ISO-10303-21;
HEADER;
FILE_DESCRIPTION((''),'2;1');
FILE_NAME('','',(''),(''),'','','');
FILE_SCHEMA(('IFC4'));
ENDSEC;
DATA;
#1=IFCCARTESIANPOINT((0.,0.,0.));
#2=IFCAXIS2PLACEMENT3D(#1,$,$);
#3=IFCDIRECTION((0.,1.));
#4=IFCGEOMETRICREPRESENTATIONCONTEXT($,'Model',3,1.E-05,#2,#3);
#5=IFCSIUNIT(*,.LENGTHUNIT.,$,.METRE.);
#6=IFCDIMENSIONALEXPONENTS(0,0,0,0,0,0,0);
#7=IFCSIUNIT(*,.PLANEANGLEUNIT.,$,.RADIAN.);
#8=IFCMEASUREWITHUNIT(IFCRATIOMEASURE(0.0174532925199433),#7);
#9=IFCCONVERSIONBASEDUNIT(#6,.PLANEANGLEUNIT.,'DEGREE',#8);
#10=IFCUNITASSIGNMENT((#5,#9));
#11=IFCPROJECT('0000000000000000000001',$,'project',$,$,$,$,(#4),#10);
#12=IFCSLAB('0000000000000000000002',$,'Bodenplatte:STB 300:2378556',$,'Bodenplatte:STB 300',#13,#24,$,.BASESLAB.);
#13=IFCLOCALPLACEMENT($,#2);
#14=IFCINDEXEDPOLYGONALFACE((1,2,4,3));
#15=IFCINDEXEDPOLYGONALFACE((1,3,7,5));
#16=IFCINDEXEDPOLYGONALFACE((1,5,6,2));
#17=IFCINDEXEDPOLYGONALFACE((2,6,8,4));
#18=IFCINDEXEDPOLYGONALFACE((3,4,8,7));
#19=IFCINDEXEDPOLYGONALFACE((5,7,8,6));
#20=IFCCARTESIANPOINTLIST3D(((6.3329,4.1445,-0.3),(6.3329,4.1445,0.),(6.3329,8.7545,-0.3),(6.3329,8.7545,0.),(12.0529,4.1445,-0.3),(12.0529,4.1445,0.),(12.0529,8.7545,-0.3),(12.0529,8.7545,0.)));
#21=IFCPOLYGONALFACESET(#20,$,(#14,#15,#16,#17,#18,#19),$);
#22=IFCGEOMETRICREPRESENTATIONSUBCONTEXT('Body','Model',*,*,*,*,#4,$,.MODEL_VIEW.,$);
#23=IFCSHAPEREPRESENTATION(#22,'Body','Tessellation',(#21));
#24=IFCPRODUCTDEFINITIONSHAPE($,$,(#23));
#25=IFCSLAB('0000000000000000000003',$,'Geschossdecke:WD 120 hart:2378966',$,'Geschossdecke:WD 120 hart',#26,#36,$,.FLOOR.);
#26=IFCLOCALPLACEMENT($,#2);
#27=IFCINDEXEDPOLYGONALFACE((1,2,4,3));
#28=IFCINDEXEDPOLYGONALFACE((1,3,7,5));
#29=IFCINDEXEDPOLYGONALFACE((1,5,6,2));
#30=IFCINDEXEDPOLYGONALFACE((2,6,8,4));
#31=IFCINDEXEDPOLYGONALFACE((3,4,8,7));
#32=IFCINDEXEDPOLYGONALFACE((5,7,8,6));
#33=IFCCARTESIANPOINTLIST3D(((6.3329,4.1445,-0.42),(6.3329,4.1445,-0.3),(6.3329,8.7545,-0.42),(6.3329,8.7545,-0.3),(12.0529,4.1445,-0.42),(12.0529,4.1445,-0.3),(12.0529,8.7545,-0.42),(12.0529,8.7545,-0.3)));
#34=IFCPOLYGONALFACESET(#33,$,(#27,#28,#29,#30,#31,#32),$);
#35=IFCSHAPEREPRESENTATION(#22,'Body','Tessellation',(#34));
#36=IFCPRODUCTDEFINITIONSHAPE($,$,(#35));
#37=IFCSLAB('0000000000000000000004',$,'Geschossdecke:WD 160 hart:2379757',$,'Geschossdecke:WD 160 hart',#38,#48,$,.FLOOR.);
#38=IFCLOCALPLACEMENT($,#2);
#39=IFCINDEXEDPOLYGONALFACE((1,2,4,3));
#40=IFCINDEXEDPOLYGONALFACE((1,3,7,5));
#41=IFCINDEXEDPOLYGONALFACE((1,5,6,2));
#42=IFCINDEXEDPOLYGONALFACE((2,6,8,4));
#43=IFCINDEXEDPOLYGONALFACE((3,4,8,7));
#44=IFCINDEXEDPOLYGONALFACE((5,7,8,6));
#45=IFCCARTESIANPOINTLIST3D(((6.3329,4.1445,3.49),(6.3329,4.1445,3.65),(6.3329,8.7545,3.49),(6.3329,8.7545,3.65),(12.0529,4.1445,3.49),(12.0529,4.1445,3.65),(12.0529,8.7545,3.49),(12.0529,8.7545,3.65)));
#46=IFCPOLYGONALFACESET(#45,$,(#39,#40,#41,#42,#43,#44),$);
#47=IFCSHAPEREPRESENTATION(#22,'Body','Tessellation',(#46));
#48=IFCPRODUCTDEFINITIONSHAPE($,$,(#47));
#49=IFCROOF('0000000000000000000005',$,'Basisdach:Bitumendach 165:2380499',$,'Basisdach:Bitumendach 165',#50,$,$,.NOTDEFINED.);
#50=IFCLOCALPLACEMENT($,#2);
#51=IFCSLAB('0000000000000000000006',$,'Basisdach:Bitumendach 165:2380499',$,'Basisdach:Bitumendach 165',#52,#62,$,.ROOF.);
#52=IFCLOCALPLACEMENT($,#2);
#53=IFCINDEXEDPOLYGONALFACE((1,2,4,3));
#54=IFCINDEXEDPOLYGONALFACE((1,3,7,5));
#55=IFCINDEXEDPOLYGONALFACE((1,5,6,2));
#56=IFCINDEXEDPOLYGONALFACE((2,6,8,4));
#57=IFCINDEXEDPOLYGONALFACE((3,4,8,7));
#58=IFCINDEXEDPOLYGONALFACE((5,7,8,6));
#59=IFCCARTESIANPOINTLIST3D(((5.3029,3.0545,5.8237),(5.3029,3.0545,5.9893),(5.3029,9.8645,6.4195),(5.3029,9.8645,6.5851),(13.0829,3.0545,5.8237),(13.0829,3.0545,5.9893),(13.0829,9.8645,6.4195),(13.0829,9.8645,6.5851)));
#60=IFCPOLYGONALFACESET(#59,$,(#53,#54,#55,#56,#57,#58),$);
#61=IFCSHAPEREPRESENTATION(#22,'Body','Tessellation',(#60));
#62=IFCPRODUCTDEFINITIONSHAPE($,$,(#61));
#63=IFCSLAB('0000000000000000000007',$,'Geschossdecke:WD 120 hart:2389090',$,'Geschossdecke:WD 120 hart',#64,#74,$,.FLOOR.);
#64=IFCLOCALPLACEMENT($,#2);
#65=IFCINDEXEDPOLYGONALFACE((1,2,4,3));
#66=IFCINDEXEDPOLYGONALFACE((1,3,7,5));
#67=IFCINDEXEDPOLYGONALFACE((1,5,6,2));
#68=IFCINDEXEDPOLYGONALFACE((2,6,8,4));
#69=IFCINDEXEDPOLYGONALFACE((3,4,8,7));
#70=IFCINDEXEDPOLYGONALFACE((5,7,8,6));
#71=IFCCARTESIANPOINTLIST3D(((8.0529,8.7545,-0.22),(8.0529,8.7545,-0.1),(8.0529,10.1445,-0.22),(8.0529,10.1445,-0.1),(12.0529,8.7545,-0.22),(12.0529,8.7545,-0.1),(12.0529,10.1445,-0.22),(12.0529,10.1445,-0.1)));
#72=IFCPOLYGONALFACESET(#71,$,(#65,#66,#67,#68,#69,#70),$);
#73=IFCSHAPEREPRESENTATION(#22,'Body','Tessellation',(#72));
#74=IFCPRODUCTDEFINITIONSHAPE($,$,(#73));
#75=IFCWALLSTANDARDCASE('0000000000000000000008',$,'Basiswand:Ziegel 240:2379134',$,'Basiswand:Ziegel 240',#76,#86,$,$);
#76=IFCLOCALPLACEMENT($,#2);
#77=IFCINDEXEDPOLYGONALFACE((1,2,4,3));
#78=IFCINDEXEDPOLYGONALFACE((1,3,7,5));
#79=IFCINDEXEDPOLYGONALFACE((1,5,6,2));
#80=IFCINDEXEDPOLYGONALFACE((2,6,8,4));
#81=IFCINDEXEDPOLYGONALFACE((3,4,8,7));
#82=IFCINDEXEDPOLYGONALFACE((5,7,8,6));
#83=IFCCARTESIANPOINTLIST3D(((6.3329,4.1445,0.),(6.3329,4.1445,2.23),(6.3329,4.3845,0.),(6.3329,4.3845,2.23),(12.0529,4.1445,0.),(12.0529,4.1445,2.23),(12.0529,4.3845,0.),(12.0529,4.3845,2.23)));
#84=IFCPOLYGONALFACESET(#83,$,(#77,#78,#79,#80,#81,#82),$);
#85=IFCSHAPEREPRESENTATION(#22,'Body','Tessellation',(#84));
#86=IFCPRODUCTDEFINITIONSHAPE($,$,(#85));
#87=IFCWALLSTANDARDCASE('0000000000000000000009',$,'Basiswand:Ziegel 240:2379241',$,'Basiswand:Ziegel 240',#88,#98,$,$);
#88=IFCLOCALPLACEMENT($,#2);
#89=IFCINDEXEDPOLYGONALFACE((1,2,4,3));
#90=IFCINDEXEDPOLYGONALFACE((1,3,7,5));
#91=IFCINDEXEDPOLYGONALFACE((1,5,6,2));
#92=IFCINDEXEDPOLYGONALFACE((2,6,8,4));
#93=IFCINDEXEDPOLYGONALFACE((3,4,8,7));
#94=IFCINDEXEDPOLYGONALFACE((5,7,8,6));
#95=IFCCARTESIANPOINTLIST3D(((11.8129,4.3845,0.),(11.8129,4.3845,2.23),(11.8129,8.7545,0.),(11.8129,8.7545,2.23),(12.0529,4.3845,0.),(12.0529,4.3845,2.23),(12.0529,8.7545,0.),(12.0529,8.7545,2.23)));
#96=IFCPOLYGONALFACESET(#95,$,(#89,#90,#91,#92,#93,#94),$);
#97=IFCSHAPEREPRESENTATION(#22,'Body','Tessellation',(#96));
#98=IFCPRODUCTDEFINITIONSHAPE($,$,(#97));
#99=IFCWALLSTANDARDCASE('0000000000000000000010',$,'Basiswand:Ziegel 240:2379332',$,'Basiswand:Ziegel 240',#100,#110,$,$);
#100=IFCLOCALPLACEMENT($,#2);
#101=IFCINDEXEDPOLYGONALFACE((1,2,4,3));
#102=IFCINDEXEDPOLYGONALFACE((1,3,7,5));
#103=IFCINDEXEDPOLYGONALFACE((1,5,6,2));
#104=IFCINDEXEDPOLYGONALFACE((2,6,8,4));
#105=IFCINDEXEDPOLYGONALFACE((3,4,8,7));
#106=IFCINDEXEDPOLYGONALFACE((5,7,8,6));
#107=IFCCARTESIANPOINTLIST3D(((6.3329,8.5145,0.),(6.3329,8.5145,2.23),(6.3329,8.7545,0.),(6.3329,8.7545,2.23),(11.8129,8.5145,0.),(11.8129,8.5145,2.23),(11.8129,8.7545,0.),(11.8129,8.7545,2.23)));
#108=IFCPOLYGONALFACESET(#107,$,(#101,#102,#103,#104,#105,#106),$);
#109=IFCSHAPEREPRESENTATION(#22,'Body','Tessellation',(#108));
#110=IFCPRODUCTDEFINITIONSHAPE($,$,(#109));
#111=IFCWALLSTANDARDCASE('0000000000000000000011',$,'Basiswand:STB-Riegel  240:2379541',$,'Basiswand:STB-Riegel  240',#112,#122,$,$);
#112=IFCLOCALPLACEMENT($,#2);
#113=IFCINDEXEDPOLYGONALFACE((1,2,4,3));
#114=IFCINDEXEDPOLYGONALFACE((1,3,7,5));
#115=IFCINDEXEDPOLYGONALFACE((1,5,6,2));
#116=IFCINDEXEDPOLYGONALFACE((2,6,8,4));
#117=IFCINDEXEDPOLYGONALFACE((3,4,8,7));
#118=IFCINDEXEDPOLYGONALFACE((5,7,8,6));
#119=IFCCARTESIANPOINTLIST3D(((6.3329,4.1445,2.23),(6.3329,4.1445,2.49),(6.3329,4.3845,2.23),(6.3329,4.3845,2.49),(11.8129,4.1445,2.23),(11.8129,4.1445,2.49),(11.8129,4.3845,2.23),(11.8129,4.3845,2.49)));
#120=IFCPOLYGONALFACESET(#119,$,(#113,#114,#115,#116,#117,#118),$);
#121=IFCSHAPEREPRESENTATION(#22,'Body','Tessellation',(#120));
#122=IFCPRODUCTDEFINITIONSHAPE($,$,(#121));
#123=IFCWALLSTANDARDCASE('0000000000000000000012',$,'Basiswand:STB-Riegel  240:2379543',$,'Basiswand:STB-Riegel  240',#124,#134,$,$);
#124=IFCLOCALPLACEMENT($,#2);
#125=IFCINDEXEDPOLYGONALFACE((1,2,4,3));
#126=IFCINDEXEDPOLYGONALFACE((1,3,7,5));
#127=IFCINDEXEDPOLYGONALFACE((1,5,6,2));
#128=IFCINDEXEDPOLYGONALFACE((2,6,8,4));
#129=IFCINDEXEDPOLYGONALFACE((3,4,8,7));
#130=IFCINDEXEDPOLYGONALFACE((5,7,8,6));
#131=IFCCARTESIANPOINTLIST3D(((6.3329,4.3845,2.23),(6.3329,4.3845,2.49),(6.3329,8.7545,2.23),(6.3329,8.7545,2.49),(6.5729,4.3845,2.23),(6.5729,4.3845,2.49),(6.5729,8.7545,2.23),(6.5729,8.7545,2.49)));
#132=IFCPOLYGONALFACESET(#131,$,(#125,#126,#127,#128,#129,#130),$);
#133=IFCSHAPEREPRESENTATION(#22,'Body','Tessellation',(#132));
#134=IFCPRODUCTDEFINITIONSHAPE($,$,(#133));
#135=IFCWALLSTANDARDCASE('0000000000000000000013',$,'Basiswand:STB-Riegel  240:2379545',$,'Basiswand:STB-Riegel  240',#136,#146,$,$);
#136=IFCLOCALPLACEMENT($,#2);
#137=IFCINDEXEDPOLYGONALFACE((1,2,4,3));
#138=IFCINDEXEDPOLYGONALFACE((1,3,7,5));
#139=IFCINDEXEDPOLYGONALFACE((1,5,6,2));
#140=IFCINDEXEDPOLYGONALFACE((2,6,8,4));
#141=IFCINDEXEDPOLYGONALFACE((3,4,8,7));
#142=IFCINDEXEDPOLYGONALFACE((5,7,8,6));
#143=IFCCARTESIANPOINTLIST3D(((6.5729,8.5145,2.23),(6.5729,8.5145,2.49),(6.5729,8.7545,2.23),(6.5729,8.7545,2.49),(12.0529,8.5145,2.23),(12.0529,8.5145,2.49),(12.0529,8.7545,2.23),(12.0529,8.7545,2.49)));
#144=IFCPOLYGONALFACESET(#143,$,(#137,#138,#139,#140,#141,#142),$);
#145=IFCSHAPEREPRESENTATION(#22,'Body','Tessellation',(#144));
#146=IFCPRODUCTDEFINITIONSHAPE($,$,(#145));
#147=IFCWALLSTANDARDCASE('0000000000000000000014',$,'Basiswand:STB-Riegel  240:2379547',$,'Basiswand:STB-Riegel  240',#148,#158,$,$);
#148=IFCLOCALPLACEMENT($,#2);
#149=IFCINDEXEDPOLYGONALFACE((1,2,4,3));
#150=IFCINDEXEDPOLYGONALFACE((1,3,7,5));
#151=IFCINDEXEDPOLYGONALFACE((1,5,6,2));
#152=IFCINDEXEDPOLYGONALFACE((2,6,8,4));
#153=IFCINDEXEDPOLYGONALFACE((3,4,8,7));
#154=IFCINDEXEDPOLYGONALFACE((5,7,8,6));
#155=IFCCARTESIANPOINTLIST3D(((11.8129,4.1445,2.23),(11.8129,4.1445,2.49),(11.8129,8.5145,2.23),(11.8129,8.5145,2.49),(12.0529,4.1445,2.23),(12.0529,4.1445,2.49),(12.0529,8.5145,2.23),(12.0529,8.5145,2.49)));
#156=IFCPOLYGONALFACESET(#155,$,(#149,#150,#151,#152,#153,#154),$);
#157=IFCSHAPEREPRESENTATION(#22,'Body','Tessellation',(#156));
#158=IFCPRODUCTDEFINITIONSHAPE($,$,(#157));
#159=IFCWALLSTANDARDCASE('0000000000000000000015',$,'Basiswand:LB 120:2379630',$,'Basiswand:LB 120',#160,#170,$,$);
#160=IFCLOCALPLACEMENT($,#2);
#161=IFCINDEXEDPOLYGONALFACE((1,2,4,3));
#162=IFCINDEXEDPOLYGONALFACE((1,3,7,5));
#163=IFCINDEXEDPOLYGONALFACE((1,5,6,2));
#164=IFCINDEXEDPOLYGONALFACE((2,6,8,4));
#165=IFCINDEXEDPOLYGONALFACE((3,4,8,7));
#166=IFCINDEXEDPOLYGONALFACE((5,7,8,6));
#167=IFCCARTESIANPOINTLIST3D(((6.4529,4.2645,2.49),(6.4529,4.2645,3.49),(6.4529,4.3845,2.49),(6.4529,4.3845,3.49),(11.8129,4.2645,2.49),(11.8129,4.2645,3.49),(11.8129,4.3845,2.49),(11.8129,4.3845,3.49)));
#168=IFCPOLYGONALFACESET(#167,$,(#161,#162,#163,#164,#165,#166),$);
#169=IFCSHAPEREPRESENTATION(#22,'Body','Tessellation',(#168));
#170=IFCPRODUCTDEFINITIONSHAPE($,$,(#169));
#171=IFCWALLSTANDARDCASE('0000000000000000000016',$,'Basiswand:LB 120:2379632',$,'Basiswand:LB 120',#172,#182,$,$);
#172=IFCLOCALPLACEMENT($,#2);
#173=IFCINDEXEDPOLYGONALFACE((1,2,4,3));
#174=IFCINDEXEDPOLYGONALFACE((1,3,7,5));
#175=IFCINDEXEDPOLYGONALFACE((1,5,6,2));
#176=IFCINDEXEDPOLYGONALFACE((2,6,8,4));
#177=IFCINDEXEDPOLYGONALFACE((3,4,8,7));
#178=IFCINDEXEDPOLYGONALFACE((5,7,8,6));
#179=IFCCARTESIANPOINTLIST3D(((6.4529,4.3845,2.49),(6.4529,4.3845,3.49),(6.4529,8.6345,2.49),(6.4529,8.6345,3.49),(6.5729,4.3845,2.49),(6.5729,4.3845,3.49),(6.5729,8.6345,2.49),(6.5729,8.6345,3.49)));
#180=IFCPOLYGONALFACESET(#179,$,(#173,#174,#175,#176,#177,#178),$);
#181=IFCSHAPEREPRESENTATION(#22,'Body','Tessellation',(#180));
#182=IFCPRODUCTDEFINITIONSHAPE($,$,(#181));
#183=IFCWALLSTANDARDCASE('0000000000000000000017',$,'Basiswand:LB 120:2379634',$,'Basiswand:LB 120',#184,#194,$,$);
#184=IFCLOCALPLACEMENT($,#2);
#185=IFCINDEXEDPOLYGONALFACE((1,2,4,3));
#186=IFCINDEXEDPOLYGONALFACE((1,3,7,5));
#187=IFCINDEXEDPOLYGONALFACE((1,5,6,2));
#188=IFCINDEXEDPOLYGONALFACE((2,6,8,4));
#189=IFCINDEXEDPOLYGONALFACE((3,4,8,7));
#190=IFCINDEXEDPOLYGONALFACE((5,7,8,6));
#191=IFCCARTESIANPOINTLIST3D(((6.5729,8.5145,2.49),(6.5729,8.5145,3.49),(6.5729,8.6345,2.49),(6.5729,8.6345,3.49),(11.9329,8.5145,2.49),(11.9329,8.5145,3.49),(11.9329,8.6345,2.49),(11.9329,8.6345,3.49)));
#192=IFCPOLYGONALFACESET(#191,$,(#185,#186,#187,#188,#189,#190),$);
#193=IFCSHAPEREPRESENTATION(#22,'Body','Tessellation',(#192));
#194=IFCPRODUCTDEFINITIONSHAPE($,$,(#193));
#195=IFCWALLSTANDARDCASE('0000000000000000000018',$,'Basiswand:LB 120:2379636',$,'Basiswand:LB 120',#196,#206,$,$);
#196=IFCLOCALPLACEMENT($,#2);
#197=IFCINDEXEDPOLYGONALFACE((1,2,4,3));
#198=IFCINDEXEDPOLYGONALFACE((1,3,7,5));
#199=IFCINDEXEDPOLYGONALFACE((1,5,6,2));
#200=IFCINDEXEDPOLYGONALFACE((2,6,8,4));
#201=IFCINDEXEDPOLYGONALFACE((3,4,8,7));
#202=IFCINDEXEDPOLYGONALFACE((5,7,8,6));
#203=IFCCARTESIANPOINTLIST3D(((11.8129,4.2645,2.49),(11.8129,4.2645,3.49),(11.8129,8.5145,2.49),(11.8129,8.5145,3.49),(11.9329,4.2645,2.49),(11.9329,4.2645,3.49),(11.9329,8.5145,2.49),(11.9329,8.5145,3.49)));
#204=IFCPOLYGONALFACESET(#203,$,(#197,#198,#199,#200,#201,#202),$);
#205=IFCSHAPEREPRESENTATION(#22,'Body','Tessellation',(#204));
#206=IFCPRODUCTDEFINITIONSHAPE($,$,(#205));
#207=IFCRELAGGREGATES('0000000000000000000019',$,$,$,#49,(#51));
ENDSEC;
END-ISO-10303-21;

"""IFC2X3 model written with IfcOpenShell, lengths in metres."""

from ifc_helpers import new_model, entity, si_unit, converted_unit, direction, frame, frame_2d, origin, place, context, subcontext, project, rectangle, extrude, element, aggregate, save


model = new_model("IFC2X3")

# Units and contexts
model_context = context("Model", 3, precision=1e-05, world=origin(), true_north=direction((0.0, 1.0)))
body_context = subcontext(model_context, "Body", "Model", "MODEL_VIEW")
ifc_project = project(units=[si_unit("LENGTHUNIT", "METRE"), converted_unit("PLANEANGLEUNIT", "DEGREE", entity("IfcRatioMeasure", 0.0174532925199433), si_unit("PLANEANGLEUNIT", "RADIAN"), dimensions=[0, 0, 0, 0, 0, 0, 0])], contexts=[model_context])

# Shared definitions
placement_1 = place(None, origin())
placement_2 = place(placement_1, origin())
placement_3 = place(placement_2, origin())

# Slabs
slab_1_placement = place(placement_3, origin())
element("IfcSlab", 1, at=slab_1_placement, Name="Bodenplatte:STB 300:2378556", ObjectType="Bodenplatte:STB 300", PredefinedType="BASESLAB", context=body_context, shape_type="SweptSolid", body=[
    extrude(rectangle(XDim=4.61, YDim=5.72, at=frame_2d((0.0, 0.0), x_axis=(1.0, 0.0))), frame((9.1929, 6.4495, 0.0), z_axis=(0.0, 0.0, -1.0), x_axis=(0.0, 1.0, 0.0)), (0.0, 0.0, 1.0), 0.3),
])
slab_2_placement = place(placement_3, origin())
element("IfcSlab", 2, at=slab_2_placement, Name="Geschossdecke:WD 120 hart:2378966", ObjectType="Geschossdecke:WD 120 hart", PredefinedType="FLOOR", context=body_context, shape_type="SweptSolid", body=[
    extrude(rectangle(XDim=4.61, YDim=5.72, at=frame_2d((0.0, 0.0), x_axis=(1.0, 0.0))), frame((9.1929, 6.4495, -0.3), z_axis=(0.0, 0.0, -1.0), x_axis=(0.0, 1.0, 0.0)), (0.0, 0.0, 1.0), 0.12),
])
placement_4 = place(placement_2, frame((0.0, 0.0, 3.65)))
slab_3_placement = place(placement_4, origin())
element("IfcSlab", 3, at=slab_3_placement, Name="Geschossdecke:WD 160 hart:2379757", ObjectType="Geschossdecke:WD 160 hart", PredefinedType="FLOOR", context=body_context, shape_type="SweptSolid", body=[
    extrude(rectangle(XDim=4.61, YDim=5.72, at=frame_2d((0.0, 0.0), x_axis=(1.0, 0.0))), frame((9.1929, 6.4495, 0.0), z_axis=(0.0, 0.0, -1.0), x_axis=(0.0, 1.0, 0.0)), (0.0, 0.0, 1.0), 0.16),
])

# Roof, slab
roof_placement = place(placement_4, frame((5.3029, 3.0545, 2.1737)))
roof = element("IfcRoof", 4, at=roof_placement, Name="Basisdach:Bitumendach 165:2380499", ObjectType="Basisdach:Bitumendach 165", ShapeType="NOTDEFINED")
slab_4_placement = place(roof_placement, origin())
slab_4 = element("IfcSlab", 5, at=slab_4_placement, Name="Basisdach:Bitumendach 165:2380499", ObjectType="Basisdach:Bitumendach 165", PredefinedType="ROOF", context=body_context, shape_type="SweptSolid", body=[
    extrude(rectangle(XDim=6.836, YDim=7.78, at=frame_2d((0.0, 0.0), x_axis=(0.0, -1.0))), frame((3.89, 3.405, 0.2979), z_axis=(0.0, -0.087156, 0.996195), x_axis=(1.0, 0.0, 0.0)), (0.0, 0.087156, 0.996195), 0.1656),
])
aggregate(roof, [slab_4])

# Slab
slab_5_placement = place(placement_3, origin())
element("IfcSlab", 6, at=slab_5_placement, Name="Geschossdecke:WD 120 hart:2389090", ObjectType="Geschossdecke:WD 120 hart", PredefinedType="FLOOR", context=body_context, shape_type="SweptSolid", body=[
    extrude(rectangle(XDim=1.39, YDim=4.0, at=frame_2d((0.0, 0.0), x_axis=(1.0, 0.0))), frame((10.0529, 9.4495, -0.1), z_axis=(0.0, 0.0, -1.0), x_axis=(0.0, 1.0, 0.0)), (0.0, 0.0, 1.0), 0.12),
])

# Walls
wall_1_placement = place(placement_3, frame((6.3329, 4.2645, 0.0)))
element("IfcWallStandardCase", 7, at=wall_1_placement, Name="Basiswand:Ziegel 240:2379134", ObjectType="Basiswand:Ziegel 240", context=body_context, shape_type="SweptSolid", body=[
    extrude(rectangle(XDim=5.72, YDim=0.24, at=frame_2d((2.86, 0.0), x_axis=(-1.0, 0.0))), origin(), (0.0, 0.0, 1.0), 2.23),
])
wall_2_placement = place(placement_3, frame((11.9329, 4.3845, 0.0), z_axis=(0.0, 0.0, 1.0), x_axis=(0.0, 1.0, 0.0)))
element("IfcWallStandardCase", 8, at=wall_2_placement, Name="Basiswand:Ziegel 240:2379241", ObjectType="Basiswand:Ziegel 240", context=body_context, shape_type="SweptSolid", body=[
    extrude(rectangle(XDim=4.37, YDim=0.24, at=frame_2d((2.185, 0.0), x_axis=(-1.0, 0.0))), origin(), (0.0, 0.0, 1.0), 2.23),
])
wall_3_placement = place(placement_3, frame((11.8129, 8.6345, 0.0), z_axis=(0.0, 0.0, 1.0), x_axis=(-1.0, 0.0, 0.0)))
element("IfcWallStandardCase", 9, at=wall_3_placement, Name="Basiswand:Ziegel 240:2379332", ObjectType="Basiswand:Ziegel 240", context=body_context, shape_type="SweptSolid", body=[
    extrude(rectangle(XDim=5.48, YDim=0.24, at=frame_2d((2.74, 0.0), x_axis=(-1.0, 0.0))), origin(), (0.0, 0.0, 1.0), 2.23),
])
wall_4_placement = place(placement_3, frame((6.3329, 4.2645, 2.23)))
element("IfcWallStandardCase", 10, at=wall_4_placement, Name="Basiswand:STB-Riegel  240:2379541", ObjectType="Basiswand:STB-Riegel  240", context=body_context, shape_type="SweptSolid", body=[
    extrude(rectangle(XDim=5.48, YDim=0.24, at=frame_2d((2.74, 0.0), x_axis=(-1.0, 0.0))), origin(), (0.0, 0.0, 1.0), 0.26),
])
wall_5_placement = place(placement_3, frame((6.4529, 8.7545, 2.23), z_axis=(0.0, 0.0, 1.0), x_axis=(0.0, -1.0, 0.0)))
element("IfcWallStandardCase", 11, at=wall_5_placement, Name="Basiswand:STB-Riegel  240:2379543", ObjectType="Basiswand:STB-Riegel  240", context=body_context, shape_type="SweptSolid", body=[
    extrude(rectangle(XDim=4.37, YDim=0.24, at=frame_2d((2.185, 0.0), x_axis=(-1.0, 0.0))), origin(), (0.0, 0.0, 1.0), 0.26),
])
wall_6_placement = place(placement_3, frame((12.0529, 8.6345, 2.23), z_axis=(0.0, 0.0, 1.0), x_axis=(-1.0, 0.0, 0.0)))
element("IfcWallStandardCase", 12, at=wall_6_placement, Name="Basiswand:STB-Riegel  240:2379545", ObjectType="Basiswand:STB-Riegel  240", context=body_context, shape_type="SweptSolid", body=[
    extrude(rectangle(XDim=5.48, YDim=0.24, at=frame_2d((2.74, 0.0), x_axis=(-1.0, 0.0))), origin(), (0.0, 0.0, 1.0), 0.26),
])
wall_7_placement = place(placement_3, frame((11.9329, 4.1445, 2.23), z_axis=(0.0, 0.0, 1.0), x_axis=(0.0, 1.0, 0.0)))
element("IfcWallStandardCase", 13, at=wall_7_placement, Name="Basiswand:STB-Riegel  240:2379547", ObjectType="Basiswand:STB-Riegel  240", context=body_context, shape_type="SweptSolid", body=[
    extrude(rectangle(XDim=4.37, YDim=0.24, at=frame_2d((2.185, 0.0), x_axis=(-1.0, 0.0))), origin(), (0.0, 0.0, 1.0), 0.26),
])
wall_8_placement = place(placement_3, frame((6.4529, 4.3245, 2.49)))
element("IfcWallStandardCase", 14, at=wall_8_placement, Name="Basiswand:LB 120:2379630", ObjectType="Basiswand:LB 120", context=body_context, shape_type="SweptSolid", body=[
    extrude(rectangle(XDim=5.36, YDim=0.12, at=frame_2d((2.68, 0.0), x_axis=(-1.0, 0.0))), origin(), (0.0, 0.0, 1.0), 1.0),
])
wall_9_placement = place(placement_3, frame((6.5129, 8.6345, 2.49), z_axis=(0.0, 0.0, 1.0), x_axis=(0.0, -1.0, 0.0)))
element("IfcWallStandardCase", 15, at=wall_9_placement, Name="Basiswand:LB 120:2379632", ObjectType="Basiswand:LB 120", context=body_context, shape_type="SweptSolid", body=[
    extrude(rectangle(XDim=4.25, YDim=0.12, at=frame_2d((2.125, 0.0), x_axis=(-1.0, 0.0))), origin(), (0.0, 0.0, 1.0), 1.0),
])
wall_10_placement = place(placement_3, frame((11.9329, 8.5745, 2.49), z_axis=(0.0, 0.0, 1.0), x_axis=(-1.0, 0.0, 0.0)))
element("IfcWallStandardCase", 16, at=wall_10_placement, Name="Basiswand:LB 120:2379634", ObjectType="Basiswand:LB 120", context=body_context, shape_type="SweptSolid", body=[
    extrude(rectangle(XDim=5.36, YDim=0.12, at=frame_2d((2.68, 0.0), x_axis=(-1.0, 0.0))), origin(), (0.0, 0.0, 1.0), 1.0),
])
wall_11_placement = place(placement_3, frame((11.8729, 4.2645, 2.49), z_axis=(0.0, 0.0, 1.0), x_axis=(0.0, 1.0, 0.0)))
element("IfcWallStandardCase", 17, at=wall_11_placement, Name="Basiswand:LB 120:2379636", ObjectType="Basiswand:LB 120", context=body_context, shape_type="SweptSolid", body=[
    extrude(rectangle(XDim=4.25, YDim=0.12, at=frame_2d((2.125, 0.0), x_axis=(-1.0, 0.0))), origin(), (0.0, 0.0, 1.0), 1.0),
])

save(model, "model.ifc")
